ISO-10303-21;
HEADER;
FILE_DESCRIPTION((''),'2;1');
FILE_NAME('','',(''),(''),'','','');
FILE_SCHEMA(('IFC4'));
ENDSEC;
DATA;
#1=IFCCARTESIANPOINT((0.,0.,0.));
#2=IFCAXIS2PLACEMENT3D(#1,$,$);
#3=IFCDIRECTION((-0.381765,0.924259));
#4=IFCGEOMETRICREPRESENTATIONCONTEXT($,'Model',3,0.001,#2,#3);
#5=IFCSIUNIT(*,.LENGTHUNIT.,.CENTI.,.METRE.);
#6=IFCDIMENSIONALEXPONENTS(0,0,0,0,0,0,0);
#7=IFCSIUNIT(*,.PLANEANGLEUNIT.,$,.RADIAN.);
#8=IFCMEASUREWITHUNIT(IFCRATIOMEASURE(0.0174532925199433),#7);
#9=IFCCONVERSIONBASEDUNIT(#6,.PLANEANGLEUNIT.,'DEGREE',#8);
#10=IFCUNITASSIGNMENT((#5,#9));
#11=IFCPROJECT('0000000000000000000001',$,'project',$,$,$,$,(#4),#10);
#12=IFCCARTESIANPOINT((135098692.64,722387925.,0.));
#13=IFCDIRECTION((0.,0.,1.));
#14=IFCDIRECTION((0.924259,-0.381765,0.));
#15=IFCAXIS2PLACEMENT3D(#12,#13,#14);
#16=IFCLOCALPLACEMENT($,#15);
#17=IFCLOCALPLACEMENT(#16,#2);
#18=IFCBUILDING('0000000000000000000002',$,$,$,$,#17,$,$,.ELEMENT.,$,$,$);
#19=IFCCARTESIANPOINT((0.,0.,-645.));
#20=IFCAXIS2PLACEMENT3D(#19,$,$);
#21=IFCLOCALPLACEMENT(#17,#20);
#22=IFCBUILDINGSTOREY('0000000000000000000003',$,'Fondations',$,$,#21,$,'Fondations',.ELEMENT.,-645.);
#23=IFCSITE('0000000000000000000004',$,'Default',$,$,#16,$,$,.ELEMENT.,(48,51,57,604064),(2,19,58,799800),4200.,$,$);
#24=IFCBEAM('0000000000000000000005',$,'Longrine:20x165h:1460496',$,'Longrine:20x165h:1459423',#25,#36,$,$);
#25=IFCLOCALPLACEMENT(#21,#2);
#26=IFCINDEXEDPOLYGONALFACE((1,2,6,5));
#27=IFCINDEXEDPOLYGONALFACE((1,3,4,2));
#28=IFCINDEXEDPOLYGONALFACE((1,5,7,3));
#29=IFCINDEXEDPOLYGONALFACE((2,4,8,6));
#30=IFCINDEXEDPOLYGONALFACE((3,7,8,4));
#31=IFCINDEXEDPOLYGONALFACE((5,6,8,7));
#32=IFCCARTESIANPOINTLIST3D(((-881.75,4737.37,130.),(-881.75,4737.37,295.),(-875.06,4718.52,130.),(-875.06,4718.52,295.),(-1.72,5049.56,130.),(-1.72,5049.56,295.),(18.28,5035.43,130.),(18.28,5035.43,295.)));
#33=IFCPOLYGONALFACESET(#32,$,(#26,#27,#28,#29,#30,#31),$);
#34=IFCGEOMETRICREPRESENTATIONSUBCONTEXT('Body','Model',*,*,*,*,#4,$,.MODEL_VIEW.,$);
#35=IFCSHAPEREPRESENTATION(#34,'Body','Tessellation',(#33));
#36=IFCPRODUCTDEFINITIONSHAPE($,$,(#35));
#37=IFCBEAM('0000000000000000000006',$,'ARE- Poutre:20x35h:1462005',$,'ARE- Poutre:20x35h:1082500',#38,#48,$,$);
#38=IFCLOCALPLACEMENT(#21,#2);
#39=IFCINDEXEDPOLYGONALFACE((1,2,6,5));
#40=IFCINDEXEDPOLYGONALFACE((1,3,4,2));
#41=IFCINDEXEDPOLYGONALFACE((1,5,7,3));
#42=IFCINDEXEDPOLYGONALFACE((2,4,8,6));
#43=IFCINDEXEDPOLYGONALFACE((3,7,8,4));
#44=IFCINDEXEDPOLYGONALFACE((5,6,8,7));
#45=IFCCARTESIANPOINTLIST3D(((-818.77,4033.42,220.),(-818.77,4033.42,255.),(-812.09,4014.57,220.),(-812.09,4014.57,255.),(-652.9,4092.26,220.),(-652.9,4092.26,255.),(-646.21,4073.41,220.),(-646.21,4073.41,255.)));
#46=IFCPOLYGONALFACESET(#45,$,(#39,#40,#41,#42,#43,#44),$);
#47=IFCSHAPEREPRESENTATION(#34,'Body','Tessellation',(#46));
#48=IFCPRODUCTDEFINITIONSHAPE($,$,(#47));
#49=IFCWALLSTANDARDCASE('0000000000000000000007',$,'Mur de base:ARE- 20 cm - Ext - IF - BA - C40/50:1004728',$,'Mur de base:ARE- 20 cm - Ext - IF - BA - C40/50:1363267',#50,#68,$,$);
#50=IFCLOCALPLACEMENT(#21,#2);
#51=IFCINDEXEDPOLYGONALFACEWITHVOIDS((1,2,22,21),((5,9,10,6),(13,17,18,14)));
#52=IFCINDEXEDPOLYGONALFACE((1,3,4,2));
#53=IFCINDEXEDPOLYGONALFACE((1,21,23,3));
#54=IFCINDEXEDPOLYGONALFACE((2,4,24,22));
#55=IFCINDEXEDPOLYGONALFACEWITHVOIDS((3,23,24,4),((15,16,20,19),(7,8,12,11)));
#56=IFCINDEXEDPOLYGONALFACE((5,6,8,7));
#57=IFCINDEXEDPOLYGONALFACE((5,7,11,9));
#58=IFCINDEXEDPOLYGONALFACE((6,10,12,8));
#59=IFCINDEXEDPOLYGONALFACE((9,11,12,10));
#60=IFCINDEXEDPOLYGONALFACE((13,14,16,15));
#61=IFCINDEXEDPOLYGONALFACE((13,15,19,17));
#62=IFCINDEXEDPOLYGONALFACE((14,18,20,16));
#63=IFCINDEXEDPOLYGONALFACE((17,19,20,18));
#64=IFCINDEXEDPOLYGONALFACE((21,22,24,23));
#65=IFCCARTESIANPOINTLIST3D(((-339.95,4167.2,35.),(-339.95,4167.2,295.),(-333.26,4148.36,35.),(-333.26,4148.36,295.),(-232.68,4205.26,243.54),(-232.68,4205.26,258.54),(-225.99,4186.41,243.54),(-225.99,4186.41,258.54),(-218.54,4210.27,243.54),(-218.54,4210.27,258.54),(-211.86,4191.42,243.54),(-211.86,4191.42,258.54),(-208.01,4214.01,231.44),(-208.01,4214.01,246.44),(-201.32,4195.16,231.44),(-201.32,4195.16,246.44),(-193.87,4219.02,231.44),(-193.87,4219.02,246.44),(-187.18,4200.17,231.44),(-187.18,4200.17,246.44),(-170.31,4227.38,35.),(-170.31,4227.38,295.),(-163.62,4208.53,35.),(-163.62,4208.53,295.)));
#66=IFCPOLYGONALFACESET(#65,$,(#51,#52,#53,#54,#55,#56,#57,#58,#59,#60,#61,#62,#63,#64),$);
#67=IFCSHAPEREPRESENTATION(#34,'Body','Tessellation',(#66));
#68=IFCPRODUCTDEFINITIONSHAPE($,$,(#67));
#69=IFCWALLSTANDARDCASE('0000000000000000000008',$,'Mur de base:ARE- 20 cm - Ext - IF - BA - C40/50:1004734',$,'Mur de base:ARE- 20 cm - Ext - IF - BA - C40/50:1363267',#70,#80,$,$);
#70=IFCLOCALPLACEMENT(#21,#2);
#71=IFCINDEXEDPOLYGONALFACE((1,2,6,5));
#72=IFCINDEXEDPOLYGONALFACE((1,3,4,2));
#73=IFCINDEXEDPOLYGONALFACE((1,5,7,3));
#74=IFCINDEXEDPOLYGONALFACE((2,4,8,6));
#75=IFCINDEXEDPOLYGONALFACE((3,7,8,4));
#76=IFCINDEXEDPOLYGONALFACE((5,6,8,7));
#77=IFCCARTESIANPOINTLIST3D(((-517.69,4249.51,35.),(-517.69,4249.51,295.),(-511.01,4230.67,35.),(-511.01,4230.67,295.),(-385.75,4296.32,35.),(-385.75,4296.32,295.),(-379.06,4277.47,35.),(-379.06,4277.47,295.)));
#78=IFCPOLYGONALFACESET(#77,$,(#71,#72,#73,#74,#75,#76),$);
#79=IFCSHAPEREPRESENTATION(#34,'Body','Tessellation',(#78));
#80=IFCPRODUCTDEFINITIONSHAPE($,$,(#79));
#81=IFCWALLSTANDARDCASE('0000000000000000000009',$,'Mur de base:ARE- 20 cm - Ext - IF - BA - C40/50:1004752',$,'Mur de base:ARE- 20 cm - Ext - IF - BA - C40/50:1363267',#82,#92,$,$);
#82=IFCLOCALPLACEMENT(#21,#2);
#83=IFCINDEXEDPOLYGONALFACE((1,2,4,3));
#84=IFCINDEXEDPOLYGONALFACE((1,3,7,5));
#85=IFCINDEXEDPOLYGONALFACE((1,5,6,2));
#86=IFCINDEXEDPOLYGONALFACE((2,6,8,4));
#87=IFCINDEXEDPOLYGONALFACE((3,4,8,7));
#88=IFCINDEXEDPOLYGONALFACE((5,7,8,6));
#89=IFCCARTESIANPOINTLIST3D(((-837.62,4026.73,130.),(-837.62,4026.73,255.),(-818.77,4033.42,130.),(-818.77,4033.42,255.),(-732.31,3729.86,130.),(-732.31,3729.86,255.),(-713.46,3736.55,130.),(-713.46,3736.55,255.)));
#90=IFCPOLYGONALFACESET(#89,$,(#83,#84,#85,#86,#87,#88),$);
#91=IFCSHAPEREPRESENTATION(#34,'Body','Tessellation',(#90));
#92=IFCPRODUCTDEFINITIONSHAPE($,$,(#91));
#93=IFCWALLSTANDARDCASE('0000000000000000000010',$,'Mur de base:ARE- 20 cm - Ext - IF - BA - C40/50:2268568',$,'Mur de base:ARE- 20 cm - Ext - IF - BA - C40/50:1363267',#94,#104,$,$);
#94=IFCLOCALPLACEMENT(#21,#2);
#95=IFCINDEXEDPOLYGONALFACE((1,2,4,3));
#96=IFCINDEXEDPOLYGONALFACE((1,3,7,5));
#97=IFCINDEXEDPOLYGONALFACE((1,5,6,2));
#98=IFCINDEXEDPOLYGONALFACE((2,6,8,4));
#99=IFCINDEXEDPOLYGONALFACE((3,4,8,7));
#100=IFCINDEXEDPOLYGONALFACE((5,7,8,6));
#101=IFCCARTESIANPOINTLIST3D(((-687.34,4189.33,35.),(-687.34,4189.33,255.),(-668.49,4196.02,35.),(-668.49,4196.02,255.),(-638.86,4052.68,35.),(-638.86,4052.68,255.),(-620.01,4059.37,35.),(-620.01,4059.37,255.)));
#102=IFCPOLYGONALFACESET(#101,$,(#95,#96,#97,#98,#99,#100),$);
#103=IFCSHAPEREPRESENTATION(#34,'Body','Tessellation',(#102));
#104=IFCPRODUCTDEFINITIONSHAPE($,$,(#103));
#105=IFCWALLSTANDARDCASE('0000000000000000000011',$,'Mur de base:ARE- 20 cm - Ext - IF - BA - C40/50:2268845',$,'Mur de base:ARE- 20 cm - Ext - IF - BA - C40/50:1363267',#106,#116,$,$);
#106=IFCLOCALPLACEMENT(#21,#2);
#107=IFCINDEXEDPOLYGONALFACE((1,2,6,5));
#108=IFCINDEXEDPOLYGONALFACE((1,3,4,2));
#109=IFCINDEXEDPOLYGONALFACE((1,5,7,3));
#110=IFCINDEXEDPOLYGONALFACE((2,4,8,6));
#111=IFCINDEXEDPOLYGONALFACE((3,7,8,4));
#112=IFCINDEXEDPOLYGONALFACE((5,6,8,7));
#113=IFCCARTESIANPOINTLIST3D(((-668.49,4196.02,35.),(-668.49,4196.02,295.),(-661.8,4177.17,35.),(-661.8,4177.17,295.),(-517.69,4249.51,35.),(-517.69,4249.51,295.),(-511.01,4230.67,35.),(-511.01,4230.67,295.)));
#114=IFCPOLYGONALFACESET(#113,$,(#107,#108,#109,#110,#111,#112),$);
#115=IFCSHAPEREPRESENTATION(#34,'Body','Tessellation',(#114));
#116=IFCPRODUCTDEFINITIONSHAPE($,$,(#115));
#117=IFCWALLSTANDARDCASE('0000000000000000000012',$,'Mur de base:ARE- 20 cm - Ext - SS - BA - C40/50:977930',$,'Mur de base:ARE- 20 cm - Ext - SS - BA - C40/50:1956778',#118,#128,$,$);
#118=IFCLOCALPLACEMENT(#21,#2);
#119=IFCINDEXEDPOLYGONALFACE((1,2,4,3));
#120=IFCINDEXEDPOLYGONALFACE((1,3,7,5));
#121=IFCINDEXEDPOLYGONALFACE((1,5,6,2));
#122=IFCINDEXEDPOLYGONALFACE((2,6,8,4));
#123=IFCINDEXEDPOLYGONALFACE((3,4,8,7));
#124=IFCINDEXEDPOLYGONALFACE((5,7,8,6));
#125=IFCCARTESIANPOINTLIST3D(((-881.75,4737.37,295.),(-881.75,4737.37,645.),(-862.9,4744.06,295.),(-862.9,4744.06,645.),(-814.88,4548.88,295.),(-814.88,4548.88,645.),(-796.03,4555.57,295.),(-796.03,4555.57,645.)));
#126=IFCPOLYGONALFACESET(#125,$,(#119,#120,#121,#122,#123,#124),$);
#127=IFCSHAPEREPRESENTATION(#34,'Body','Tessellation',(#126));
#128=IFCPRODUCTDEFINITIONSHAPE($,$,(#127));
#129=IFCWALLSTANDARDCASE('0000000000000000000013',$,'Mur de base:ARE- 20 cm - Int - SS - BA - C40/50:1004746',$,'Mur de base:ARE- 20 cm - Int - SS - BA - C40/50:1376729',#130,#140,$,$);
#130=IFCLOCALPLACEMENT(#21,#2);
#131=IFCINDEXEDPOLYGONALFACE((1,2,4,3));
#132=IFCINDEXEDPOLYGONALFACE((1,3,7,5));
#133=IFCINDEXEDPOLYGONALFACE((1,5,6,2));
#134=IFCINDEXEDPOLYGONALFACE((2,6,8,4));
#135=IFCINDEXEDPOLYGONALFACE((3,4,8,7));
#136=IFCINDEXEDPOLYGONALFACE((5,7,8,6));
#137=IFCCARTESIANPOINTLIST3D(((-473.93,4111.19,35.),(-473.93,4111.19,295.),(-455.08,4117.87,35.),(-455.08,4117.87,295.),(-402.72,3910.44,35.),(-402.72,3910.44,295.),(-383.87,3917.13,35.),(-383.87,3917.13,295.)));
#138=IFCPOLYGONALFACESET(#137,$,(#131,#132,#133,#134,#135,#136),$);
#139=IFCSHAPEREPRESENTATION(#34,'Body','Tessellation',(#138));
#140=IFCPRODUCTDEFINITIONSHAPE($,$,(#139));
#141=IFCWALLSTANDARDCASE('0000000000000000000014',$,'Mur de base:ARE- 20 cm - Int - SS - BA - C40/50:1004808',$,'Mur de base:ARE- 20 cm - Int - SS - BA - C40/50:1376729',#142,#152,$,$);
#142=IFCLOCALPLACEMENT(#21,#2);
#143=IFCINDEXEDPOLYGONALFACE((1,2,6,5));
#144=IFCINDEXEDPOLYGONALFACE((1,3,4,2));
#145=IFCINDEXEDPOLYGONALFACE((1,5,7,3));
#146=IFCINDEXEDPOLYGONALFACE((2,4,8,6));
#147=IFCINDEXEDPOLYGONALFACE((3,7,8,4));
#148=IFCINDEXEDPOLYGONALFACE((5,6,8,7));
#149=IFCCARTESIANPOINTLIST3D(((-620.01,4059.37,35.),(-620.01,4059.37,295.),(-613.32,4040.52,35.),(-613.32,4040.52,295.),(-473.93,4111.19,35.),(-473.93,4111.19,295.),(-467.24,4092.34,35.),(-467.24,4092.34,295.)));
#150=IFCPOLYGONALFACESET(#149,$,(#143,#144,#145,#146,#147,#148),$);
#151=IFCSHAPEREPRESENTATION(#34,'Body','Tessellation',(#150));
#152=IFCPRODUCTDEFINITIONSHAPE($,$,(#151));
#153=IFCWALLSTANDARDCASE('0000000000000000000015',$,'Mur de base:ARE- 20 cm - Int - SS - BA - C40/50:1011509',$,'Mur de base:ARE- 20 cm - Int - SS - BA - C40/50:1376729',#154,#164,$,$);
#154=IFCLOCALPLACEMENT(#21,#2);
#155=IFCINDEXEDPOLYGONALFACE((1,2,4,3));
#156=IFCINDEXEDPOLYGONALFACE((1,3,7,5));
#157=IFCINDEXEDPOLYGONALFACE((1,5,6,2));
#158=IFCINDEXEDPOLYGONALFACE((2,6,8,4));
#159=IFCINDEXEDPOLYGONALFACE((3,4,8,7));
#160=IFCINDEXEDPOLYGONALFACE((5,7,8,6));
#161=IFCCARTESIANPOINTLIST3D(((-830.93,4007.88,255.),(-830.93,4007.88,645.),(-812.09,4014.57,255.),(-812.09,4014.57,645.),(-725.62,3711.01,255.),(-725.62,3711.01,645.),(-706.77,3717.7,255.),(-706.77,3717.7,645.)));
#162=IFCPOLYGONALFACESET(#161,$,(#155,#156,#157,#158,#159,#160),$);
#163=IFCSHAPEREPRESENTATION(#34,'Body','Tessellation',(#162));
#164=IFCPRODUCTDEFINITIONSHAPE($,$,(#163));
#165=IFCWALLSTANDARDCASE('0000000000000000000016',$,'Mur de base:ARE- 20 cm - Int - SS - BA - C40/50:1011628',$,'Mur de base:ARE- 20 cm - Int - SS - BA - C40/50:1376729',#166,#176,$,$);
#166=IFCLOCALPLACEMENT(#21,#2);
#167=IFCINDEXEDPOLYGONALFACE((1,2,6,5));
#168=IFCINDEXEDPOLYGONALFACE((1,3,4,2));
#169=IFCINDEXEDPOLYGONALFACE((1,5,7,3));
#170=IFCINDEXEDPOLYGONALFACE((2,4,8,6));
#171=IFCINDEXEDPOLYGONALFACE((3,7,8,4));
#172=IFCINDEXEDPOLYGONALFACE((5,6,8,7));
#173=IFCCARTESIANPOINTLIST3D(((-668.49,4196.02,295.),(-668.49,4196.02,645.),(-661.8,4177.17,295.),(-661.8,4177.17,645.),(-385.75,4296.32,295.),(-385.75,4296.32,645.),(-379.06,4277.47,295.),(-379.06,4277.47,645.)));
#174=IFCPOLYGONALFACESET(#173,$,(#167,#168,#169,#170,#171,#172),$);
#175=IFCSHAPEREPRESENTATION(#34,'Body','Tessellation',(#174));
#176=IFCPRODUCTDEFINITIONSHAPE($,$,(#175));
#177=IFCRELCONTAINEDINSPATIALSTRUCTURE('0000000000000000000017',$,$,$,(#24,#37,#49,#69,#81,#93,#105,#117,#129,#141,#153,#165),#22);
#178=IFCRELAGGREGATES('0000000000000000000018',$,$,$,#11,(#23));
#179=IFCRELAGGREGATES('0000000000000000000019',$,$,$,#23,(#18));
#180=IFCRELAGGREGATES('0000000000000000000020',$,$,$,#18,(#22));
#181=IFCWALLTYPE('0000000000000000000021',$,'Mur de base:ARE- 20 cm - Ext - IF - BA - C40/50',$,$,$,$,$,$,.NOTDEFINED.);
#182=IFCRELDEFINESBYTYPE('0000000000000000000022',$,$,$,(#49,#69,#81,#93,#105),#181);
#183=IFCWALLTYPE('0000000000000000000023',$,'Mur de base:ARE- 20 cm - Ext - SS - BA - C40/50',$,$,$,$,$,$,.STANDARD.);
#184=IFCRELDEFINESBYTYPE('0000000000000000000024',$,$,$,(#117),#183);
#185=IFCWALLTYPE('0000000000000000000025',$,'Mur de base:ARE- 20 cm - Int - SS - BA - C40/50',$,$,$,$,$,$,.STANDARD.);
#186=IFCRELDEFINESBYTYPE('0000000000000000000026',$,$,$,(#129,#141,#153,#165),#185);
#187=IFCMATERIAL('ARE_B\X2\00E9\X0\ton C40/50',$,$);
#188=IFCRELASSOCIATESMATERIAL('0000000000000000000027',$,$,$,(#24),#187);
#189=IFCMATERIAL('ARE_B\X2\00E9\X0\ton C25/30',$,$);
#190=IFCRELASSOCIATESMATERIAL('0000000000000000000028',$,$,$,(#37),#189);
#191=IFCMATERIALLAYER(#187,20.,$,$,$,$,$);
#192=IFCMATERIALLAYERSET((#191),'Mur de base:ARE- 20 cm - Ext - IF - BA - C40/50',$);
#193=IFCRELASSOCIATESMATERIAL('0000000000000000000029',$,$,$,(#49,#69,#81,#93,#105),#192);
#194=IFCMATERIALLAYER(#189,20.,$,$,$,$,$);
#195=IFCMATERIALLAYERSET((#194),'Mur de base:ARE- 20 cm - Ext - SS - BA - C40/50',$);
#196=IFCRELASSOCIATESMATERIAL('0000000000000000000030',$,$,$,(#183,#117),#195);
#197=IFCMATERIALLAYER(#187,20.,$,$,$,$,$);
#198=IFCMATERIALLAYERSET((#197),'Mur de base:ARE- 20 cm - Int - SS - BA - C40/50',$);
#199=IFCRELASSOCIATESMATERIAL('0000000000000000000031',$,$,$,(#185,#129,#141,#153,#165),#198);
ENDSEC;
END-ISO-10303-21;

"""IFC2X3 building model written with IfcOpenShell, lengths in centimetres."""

from ifc_helpers import new_model, entity, si_unit, converted_unit, direction, frame, frame_2d, origin, place, context, subcontext, project, spatial, rectangle, extrude, clip, halfspace, material, layer, layer_set, layer_usage, type_object, element, save


model = new_model("IFC2X3")

# Units and contexts
model_context = context("Model", 3, precision=0.001, world=origin(), true_north=direction((-0.381765, 0.924259)))
body_context = subcontext(model_context, "Body", "Model", "MODEL_VIEW")
ifc_project = project(units=[si_unit("LENGTHUNIT", "METRE", prefix="CENTI"), converted_unit("PLANEANGLEUNIT", "DEGREE", entity("IfcRatioMeasure", 0.0174532925199433), si_unit("PLANEANGLEUNIT", "RADIAN"), dimensions=[0, 0, 0, 0, 0, 0, 0])], contexts=[model_context])

# Site, building, storey
site_placement = place(None, frame((135098692.64, 722387925.0, 0.0), z_axis=(0.0, 0.0, 1.0), x_axis=(0.924259, -0.381765, 0.0)))
site = spatial("IfcSite", under=ifc_project, at=site_placement, Name="Default", CompositionType="ELEMENT", RefLatitude=(48, 51, 57, 604064), RefLongitude=(2, 19, 58, 799800), RefElevation=4200.0)
building_placement = place(site_placement, origin())
building = spatial("IfcBuilding", under=site, at=building_placement, CompositionType="ELEMENT")
storey_placement = place(building_placement, frame((0.0, 0.0, -645.0)))
storey = spatial("IfcBuildingStorey", under=building, at=storey_placement, Name="Fondations", LongName="Fondations", CompositionType="ELEMENT", Elevation=-645.0)

# Beams
ifc_material_1 = material(Name="ARE_Béton C40/50")
beam_1_placement = place(storey_placement, frame((-868.98, 4731.29, 295.0), z_axis=(0.0, 0.0, 1.0), x_axis=(0.942456, 0.334331, 0.0)))
element("IfcBeam", 1, at=beam_1_placement, inside=storey, material=ifc_material_1, Name="Longrine:20x165h:1460496", ObjectType="Longrine:20x165h:1459423", context=body_context, shape_type="Clipping", body=[
    clip(extrude(rectangle(XDim=165.0, YDim=20.0, at=frame_2d((0.0, 0.0), x_axis=(1.0, 0.0))), frame((-10.0, 0.0, -82.5), z_axis=(1.0, 0.0, 0.0), x_axis=(0.0, 0.0, -1.0)), (0.0, 0.0, 1.0), 947.89), halfspace(frame((940.37, -13.52, -165.0), z_axis=(0.816802, 0.576918, 0.0), x_axis=(0.576918, -0.816802, 0.0)), False)),
])
ifc_material_2 = material(Name="ARE_Béton C25/30")
beam_2_placement = place(storey_placement, frame((-824.85, 4020.65, 255.0), z_axis=(0.0, 0.0, 1.0), x_axis=(0.942456, 0.334331, 0.0)))
element("IfcBeam", 2, at=beam_2_placement, inside=storey, material=ifc_material_2, Name="ARE- Poutre:20x35h:1462005", ObjectType="ARE- Poutre:20x35h:1082500", context=body_context, shape_type="SweptSolid", body=[
    extrude(rectangle(XDim=35.0, YDim=20.0, at=frame_2d((0.0, 0.0), x_axis=(1.0, 0.0))), frame((10.0, 0.0, -17.5), z_axis=(1.0, 0.0, 0.0), x_axis=(0.0, 0.0, -1.0)), (0.0, 0.0, 1.0), 176.0),
])

# Wall, openings
ifc_layer_1 = layer(ifc_material_1, 20.0)
ifc_layer_set_1 = layer_set([ifc_layer_1], Name="Mur de base:ARE- 20 cm - Ext - IF - BA - C40/50")
ifc_layer_usage_1 = layer_usage(ifc_layer_set_1, "AXIS2", "NEGATIVE", 10.0)
wall_type_1 = type_object("IfcWallType", Name="Mur de base:ARE- 20 cm - Ext - IF - BA - C40/50", PredefinedType="NOTDEFINED")
wall_1_placement = place(storey_placement, frame((-336.6, 4157.78, 35.0), z_axis=(0.0, 0.0, 1.0), x_axis=(0.942456, 0.334331, 0.0)))
wall_1 = element("IfcWallStandardCase", 3, at=wall_1_placement, inside=storey, type_object=wall_type_1, material=ifc_layer_usage_1, Name="Mur de base:ARE- 20 cm - Ext - IF - BA - C40/50:1004728", ObjectType="Mur de base:ARE- 20 cm - Ext - IF - BA - C40/50:1363267", context=body_context, shape_type="SweptSolid", body=[
    extrude(rectangle(XDim=180.0, YDim=20.0, at=frame_2d((90.0, 0.0), x_axis=(-1.0, 0.0))), origin(), (0.0, 0.0, 1.0), 260.0),
])
opening_1_placement = place(wall_1_placement, origin())
element("IfcOpeningElement", 4, at=opening_1_placement, cuts=wall_1, ObjectType="Opening", context=body_context, shape_type="SweptSolid", body=[
    extrude(rectangle(XDim=15.0, YDim=15.0, at=frame_2d((0.0, 0.0), x_axis=(0.0, 1.0))), frame((121.32, -10.0, 216.04), z_axis=(0.0, 1.0, 0.0), x_axis=(1.0, 0.0, 0.0)), (0.0, 0.0, 1.0), 20.0),
])
opening_2_placement = place(wall_1_placement, origin())
element("IfcOpeningElement", 5, at=opening_2_placement, cuts=wall_1, ObjectType="Opening", context=body_context, shape_type="SweptSolid", body=[
    extrude(rectangle(XDim=15.0, YDim=15.0, at=frame_2d((0.0, 0.0), x_axis=(0.0, 1.0))), frame((147.5, -10.0, 203.94), z_axis=(0.0, 1.0, 0.0), x_axis=(1.0, 0.0, 0.0)), (0.0, 0.0, 1.0), 20.0),
])

# Walls
ifc_layer_usage_2 = layer_usage(ifc_layer_set_1, "AXIS2", "NEGATIVE", 10.0)
wall_2_placement = place(storey_placement, frame((-382.41, 4286.9, 35.0), z_axis=(0.0, 0.0, 1.0), x_axis=(-0.942456, -0.334331, 0.0)))
element("IfcWallStandardCase", 6, at=wall_2_placement, inside=storey, type_object=wall_type_1, material=ifc_layer_usage_2, Name="Mur de base:ARE- 20 cm - Ext - IF - BA - C40/50:1004734", ObjectType="Mur de base:ARE- 20 cm - Ext - IF - BA - C40/50:1363267", context=body_context, shape_type="SweptSolid", body=[
    extrude(rectangle(XDim=140.0, YDim=20.0, at=frame_2d((70.0, 0.0), x_axis=(-1.0, 0.0))), origin(), (0.0, 0.0, 1.0), 260.0),
])
ifc_layer_usage_3 = layer_usage(ifc_layer_set_1, "AXIS2", "NEGATIVE", 10.0)
wall_3_placement = place(storey_placement, frame((-828.2, 4030.08, 130.0), z_axis=(0.0, 0.0, 1.0), x_axis=(0.334331, -0.942456, 0.0)))
element("IfcWallStandardCase", 7, at=wall_3_placement, inside=storey, type_object=wall_type_1, material=ifc_layer_usage_3, Name="Mur de base:ARE- 20 cm - Ext - IF - BA - C40/50:1004752", ObjectType="Mur de base:ARE- 20 cm - Ext - IF - BA - C40/50:1363267", context=body_context, shape_type="SweptSolid", body=[
    extrude(rectangle(XDim=315.0, YDim=20.0, at=frame_2d((157.5, 0.0), x_axis=(-1.0, 0.0))), origin(), (0.0, 0.0, 1.0), 125.0),
])
ifc_layer_usage_4 = layer_usage(ifc_layer_set_1, "AXIS2", "NEGATIVE", 10.0)
wall_4_placement = place(storey_placement, frame((-629.43, 4056.02, 35.0), z_axis=(0.0, 0.0, 1.0), x_axis=(-0.334331, 0.942456, 0.0)))
element("IfcWallStandardCase", 8, at=wall_4_placement, inside=storey, type_object=wall_type_1, material=ifc_layer_usage_4, Name="Mur de base:ARE- 20 cm - Ext - IF - BA - C40/50:2268568", ObjectType="Mur de base:ARE- 20 cm - Ext - IF - BA - C40/50:1363267", context=body_context, shape_type="SweptSolid", body=[
    extrude(rectangle(XDim=145.0, YDim=20.0, at=frame_2d((72.5, 0.0), x_axis=(-1.0, 0.0))), origin(), (0.0, 0.0, 1.0), 220.0),
])
ifc_layer_usage_5 = layer_usage(ifc_layer_set_1, "AXIS2", "NEGATIVE", 10.0)
wall_5_placement = place(storey_placement, frame((-514.35, 4240.09, 35.0), z_axis=(0.0, 0.0, 1.0), x_axis=(-0.942456, -0.334331, 0.0)))
element("IfcWallStandardCase", 9, at=wall_5_placement, inside=storey, type_object=wall_type_1, material=ifc_layer_usage_5, Name="Mur de base:ARE- 20 cm - Ext - IF - BA - C40/50:2268845", ObjectType="Mur de base:ARE- 20 cm - Ext - IF - BA - C40/50:1363267", context=body_context, shape_type="SweptSolid", body=[
    extrude(rectangle(XDim=160.0, YDim=20.0, at=frame_2d((80.0, 0.0), x_axis=(-1.0, 0.0))), origin(), (0.0, 0.0, 1.0), 260.0),
])
ifc_layer_2 = layer(ifc_material_2, 20.0)
ifc_layer_set_2 = layer_set([ifc_layer_2], Name="Mur de base:ARE- 20 cm - Ext - SS - BA - C40/50")
ifc_layer_usage_6 = layer_usage(ifc_layer_set_2, "AXIS2", "POSITIVE", -10.0)
wall_type_2 = type_object("IfcWallType", Name="Mur de base:ARE- 20 cm - Ext - SS - BA - C40/50", PredefinedType="STANDARD", material=ifc_layer_set_2)
wall_6_placement = place(storey_placement, frame((-872.33, 4740.72, 295.0), z_axis=(0.0, 0.0, 1.0), x_axis=(0.334331, -0.942456, 0.0)))
element("IfcWallStandardCase", 10, at=wall_6_placement, inside=storey, type_object=wall_type_2, material=ifc_layer_usage_6, Name="Mur de base:ARE- 20 cm - Ext - SS - BA - C40/50:977930", ObjectType="Mur de base:ARE- 20 cm - Ext - SS - BA - C40/50:1956778", context=body_context, shape_type="SweptSolid", body=[
    extrude(rectangle(XDim=200.0, YDim=20.0, at=frame_2d((100.0, 0.0), x_axis=(-1.0, 0.0))), origin(), (0.0, 0.0, 1.0), 350.0),
])
ifc_layer_3 = layer(ifc_material_1, 20.0)
ifc_layer_set_3 = layer_set([ifc_layer_3], Name="Mur de base:ARE- 20 cm - Int - SS - BA - C40/50")
ifc_layer_usage_7 = layer_usage(ifc_layer_set_3, "AXIS2", "NEGATIVE", 10.0)
wall_type_3 = type_object("IfcWallType", Name="Mur de base:ARE- 20 cm - Int - SS - BA - C40/50", PredefinedType="STANDARD", material=ifc_layer_set_3)
wall_7_placement = place(storey_placement, frame((-393.29, 3913.79, 35.0), z_axis=(0.0, 0.0, 1.0), x_axis=(-0.334331, 0.942456, 0.0)))
element("IfcWallStandardCase", 11, at=wall_7_placement, inside=storey, type_object=wall_type_3, material=ifc_layer_usage_7, Name="Mur de base:ARE- 20 cm - Int - SS - BA - C40/50:1004746", ObjectType="Mur de base:ARE- 20 cm - Int - SS - BA - C40/50:1376729", context=body_context, shape_type="SweptSolid", body=[
    extrude(rectangle(XDim=213.0, YDim=20.0, at=frame_2d((106.5, 0.0), x_axis=(-1.0, 0.0))), origin(), (0.0, 0.0, 1.0), 260.0),
])
ifc_layer_usage_8 = layer_usage(ifc_layer_set_3, "AXIS2", "NEGATIVE", 10.0)
wall_8_placement = place(storey_placement, frame((-616.67, 4049.94, 35.0), z_axis=(0.0, 0.0, 1.0), x_axis=(0.942456, 0.334331, 0.0)))
element("IfcWallStandardCase", 12, at=wall_8_placement, inside=storey, type_object=wall_type_3, material=ifc_layer_usage_8, Name="Mur de base:ARE- 20 cm - Int - SS - BA - C40/50:1004808", ObjectType="Mur de base:ARE- 20 cm - Int - SS - BA - C40/50:1376729", context=body_context, shape_type="SweptSolid", body=[
    extrude(rectangle(XDim=155.0, YDim=20.0, at=frame_2d((77.5, 0.0), x_axis=(-1.0, 0.0))), origin(), (0.0, 0.0, 1.0), 260.0),
])
ifc_layer_usage_9 = layer_usage(ifc_layer_set_3, "AXIS2", "NEGATIVE", 10.0)
wall_9_placement = place(storey_placement, frame((-821.51, 4011.23, 255.0), z_axis=(0.0, 0.0, 1.0), x_axis=(0.334331, -0.942456, 0.0)))
element("IfcWallStandardCase", 13, at=wall_9_placement, inside=storey, type_object=wall_type_3, material=ifc_layer_usage_9, Name="Mur de base:ARE- 20 cm - Int - SS - BA - C40/50:1011509", ObjectType="Mur de base:ARE- 20 cm - Int - SS - BA - C40/50:1376729", context=body_context, shape_type="SweptSolid", body=[
    extrude(rectangle(XDim=315.0, YDim=20.0, at=frame_2d((157.5, 0.0), x_axis=(-1.0, 0.0))), origin(), (0.0, 0.0, 1.0), 390.0),
])
ifc_layer_usage_10 = layer_usage(ifc_layer_set_3, "AXIS2", "NEGATIVE", 10.0)
wall_10_placement = place(storey_placement, frame((-665.14, 4186.6, 295.0), z_axis=(0.0, 0.0, 1.0), x_axis=(0.942456, 0.334331, 0.0)))
element("IfcWallStandardCase", 14, at=wall_10_placement, inside=storey, type_object=wall_type_3, material=ifc_layer_usage_10, Name="Mur de base:ARE- 20 cm - Int - SS - BA - C40/50:1011628", ObjectType="Mur de base:ARE- 20 cm - Int - SS - BA - C40/50:1376729", context=body_context, shape_type="SweptSolid", body=[
    extrude(rectangle(XDim=300.0, YDim=20.0, at=frame_2d((150.0, 0.0), x_axis=(-1.0, 0.0))), origin(), (0.0, 0.0, 1.0), 350.0),
])

save(model, "model.ifc")
